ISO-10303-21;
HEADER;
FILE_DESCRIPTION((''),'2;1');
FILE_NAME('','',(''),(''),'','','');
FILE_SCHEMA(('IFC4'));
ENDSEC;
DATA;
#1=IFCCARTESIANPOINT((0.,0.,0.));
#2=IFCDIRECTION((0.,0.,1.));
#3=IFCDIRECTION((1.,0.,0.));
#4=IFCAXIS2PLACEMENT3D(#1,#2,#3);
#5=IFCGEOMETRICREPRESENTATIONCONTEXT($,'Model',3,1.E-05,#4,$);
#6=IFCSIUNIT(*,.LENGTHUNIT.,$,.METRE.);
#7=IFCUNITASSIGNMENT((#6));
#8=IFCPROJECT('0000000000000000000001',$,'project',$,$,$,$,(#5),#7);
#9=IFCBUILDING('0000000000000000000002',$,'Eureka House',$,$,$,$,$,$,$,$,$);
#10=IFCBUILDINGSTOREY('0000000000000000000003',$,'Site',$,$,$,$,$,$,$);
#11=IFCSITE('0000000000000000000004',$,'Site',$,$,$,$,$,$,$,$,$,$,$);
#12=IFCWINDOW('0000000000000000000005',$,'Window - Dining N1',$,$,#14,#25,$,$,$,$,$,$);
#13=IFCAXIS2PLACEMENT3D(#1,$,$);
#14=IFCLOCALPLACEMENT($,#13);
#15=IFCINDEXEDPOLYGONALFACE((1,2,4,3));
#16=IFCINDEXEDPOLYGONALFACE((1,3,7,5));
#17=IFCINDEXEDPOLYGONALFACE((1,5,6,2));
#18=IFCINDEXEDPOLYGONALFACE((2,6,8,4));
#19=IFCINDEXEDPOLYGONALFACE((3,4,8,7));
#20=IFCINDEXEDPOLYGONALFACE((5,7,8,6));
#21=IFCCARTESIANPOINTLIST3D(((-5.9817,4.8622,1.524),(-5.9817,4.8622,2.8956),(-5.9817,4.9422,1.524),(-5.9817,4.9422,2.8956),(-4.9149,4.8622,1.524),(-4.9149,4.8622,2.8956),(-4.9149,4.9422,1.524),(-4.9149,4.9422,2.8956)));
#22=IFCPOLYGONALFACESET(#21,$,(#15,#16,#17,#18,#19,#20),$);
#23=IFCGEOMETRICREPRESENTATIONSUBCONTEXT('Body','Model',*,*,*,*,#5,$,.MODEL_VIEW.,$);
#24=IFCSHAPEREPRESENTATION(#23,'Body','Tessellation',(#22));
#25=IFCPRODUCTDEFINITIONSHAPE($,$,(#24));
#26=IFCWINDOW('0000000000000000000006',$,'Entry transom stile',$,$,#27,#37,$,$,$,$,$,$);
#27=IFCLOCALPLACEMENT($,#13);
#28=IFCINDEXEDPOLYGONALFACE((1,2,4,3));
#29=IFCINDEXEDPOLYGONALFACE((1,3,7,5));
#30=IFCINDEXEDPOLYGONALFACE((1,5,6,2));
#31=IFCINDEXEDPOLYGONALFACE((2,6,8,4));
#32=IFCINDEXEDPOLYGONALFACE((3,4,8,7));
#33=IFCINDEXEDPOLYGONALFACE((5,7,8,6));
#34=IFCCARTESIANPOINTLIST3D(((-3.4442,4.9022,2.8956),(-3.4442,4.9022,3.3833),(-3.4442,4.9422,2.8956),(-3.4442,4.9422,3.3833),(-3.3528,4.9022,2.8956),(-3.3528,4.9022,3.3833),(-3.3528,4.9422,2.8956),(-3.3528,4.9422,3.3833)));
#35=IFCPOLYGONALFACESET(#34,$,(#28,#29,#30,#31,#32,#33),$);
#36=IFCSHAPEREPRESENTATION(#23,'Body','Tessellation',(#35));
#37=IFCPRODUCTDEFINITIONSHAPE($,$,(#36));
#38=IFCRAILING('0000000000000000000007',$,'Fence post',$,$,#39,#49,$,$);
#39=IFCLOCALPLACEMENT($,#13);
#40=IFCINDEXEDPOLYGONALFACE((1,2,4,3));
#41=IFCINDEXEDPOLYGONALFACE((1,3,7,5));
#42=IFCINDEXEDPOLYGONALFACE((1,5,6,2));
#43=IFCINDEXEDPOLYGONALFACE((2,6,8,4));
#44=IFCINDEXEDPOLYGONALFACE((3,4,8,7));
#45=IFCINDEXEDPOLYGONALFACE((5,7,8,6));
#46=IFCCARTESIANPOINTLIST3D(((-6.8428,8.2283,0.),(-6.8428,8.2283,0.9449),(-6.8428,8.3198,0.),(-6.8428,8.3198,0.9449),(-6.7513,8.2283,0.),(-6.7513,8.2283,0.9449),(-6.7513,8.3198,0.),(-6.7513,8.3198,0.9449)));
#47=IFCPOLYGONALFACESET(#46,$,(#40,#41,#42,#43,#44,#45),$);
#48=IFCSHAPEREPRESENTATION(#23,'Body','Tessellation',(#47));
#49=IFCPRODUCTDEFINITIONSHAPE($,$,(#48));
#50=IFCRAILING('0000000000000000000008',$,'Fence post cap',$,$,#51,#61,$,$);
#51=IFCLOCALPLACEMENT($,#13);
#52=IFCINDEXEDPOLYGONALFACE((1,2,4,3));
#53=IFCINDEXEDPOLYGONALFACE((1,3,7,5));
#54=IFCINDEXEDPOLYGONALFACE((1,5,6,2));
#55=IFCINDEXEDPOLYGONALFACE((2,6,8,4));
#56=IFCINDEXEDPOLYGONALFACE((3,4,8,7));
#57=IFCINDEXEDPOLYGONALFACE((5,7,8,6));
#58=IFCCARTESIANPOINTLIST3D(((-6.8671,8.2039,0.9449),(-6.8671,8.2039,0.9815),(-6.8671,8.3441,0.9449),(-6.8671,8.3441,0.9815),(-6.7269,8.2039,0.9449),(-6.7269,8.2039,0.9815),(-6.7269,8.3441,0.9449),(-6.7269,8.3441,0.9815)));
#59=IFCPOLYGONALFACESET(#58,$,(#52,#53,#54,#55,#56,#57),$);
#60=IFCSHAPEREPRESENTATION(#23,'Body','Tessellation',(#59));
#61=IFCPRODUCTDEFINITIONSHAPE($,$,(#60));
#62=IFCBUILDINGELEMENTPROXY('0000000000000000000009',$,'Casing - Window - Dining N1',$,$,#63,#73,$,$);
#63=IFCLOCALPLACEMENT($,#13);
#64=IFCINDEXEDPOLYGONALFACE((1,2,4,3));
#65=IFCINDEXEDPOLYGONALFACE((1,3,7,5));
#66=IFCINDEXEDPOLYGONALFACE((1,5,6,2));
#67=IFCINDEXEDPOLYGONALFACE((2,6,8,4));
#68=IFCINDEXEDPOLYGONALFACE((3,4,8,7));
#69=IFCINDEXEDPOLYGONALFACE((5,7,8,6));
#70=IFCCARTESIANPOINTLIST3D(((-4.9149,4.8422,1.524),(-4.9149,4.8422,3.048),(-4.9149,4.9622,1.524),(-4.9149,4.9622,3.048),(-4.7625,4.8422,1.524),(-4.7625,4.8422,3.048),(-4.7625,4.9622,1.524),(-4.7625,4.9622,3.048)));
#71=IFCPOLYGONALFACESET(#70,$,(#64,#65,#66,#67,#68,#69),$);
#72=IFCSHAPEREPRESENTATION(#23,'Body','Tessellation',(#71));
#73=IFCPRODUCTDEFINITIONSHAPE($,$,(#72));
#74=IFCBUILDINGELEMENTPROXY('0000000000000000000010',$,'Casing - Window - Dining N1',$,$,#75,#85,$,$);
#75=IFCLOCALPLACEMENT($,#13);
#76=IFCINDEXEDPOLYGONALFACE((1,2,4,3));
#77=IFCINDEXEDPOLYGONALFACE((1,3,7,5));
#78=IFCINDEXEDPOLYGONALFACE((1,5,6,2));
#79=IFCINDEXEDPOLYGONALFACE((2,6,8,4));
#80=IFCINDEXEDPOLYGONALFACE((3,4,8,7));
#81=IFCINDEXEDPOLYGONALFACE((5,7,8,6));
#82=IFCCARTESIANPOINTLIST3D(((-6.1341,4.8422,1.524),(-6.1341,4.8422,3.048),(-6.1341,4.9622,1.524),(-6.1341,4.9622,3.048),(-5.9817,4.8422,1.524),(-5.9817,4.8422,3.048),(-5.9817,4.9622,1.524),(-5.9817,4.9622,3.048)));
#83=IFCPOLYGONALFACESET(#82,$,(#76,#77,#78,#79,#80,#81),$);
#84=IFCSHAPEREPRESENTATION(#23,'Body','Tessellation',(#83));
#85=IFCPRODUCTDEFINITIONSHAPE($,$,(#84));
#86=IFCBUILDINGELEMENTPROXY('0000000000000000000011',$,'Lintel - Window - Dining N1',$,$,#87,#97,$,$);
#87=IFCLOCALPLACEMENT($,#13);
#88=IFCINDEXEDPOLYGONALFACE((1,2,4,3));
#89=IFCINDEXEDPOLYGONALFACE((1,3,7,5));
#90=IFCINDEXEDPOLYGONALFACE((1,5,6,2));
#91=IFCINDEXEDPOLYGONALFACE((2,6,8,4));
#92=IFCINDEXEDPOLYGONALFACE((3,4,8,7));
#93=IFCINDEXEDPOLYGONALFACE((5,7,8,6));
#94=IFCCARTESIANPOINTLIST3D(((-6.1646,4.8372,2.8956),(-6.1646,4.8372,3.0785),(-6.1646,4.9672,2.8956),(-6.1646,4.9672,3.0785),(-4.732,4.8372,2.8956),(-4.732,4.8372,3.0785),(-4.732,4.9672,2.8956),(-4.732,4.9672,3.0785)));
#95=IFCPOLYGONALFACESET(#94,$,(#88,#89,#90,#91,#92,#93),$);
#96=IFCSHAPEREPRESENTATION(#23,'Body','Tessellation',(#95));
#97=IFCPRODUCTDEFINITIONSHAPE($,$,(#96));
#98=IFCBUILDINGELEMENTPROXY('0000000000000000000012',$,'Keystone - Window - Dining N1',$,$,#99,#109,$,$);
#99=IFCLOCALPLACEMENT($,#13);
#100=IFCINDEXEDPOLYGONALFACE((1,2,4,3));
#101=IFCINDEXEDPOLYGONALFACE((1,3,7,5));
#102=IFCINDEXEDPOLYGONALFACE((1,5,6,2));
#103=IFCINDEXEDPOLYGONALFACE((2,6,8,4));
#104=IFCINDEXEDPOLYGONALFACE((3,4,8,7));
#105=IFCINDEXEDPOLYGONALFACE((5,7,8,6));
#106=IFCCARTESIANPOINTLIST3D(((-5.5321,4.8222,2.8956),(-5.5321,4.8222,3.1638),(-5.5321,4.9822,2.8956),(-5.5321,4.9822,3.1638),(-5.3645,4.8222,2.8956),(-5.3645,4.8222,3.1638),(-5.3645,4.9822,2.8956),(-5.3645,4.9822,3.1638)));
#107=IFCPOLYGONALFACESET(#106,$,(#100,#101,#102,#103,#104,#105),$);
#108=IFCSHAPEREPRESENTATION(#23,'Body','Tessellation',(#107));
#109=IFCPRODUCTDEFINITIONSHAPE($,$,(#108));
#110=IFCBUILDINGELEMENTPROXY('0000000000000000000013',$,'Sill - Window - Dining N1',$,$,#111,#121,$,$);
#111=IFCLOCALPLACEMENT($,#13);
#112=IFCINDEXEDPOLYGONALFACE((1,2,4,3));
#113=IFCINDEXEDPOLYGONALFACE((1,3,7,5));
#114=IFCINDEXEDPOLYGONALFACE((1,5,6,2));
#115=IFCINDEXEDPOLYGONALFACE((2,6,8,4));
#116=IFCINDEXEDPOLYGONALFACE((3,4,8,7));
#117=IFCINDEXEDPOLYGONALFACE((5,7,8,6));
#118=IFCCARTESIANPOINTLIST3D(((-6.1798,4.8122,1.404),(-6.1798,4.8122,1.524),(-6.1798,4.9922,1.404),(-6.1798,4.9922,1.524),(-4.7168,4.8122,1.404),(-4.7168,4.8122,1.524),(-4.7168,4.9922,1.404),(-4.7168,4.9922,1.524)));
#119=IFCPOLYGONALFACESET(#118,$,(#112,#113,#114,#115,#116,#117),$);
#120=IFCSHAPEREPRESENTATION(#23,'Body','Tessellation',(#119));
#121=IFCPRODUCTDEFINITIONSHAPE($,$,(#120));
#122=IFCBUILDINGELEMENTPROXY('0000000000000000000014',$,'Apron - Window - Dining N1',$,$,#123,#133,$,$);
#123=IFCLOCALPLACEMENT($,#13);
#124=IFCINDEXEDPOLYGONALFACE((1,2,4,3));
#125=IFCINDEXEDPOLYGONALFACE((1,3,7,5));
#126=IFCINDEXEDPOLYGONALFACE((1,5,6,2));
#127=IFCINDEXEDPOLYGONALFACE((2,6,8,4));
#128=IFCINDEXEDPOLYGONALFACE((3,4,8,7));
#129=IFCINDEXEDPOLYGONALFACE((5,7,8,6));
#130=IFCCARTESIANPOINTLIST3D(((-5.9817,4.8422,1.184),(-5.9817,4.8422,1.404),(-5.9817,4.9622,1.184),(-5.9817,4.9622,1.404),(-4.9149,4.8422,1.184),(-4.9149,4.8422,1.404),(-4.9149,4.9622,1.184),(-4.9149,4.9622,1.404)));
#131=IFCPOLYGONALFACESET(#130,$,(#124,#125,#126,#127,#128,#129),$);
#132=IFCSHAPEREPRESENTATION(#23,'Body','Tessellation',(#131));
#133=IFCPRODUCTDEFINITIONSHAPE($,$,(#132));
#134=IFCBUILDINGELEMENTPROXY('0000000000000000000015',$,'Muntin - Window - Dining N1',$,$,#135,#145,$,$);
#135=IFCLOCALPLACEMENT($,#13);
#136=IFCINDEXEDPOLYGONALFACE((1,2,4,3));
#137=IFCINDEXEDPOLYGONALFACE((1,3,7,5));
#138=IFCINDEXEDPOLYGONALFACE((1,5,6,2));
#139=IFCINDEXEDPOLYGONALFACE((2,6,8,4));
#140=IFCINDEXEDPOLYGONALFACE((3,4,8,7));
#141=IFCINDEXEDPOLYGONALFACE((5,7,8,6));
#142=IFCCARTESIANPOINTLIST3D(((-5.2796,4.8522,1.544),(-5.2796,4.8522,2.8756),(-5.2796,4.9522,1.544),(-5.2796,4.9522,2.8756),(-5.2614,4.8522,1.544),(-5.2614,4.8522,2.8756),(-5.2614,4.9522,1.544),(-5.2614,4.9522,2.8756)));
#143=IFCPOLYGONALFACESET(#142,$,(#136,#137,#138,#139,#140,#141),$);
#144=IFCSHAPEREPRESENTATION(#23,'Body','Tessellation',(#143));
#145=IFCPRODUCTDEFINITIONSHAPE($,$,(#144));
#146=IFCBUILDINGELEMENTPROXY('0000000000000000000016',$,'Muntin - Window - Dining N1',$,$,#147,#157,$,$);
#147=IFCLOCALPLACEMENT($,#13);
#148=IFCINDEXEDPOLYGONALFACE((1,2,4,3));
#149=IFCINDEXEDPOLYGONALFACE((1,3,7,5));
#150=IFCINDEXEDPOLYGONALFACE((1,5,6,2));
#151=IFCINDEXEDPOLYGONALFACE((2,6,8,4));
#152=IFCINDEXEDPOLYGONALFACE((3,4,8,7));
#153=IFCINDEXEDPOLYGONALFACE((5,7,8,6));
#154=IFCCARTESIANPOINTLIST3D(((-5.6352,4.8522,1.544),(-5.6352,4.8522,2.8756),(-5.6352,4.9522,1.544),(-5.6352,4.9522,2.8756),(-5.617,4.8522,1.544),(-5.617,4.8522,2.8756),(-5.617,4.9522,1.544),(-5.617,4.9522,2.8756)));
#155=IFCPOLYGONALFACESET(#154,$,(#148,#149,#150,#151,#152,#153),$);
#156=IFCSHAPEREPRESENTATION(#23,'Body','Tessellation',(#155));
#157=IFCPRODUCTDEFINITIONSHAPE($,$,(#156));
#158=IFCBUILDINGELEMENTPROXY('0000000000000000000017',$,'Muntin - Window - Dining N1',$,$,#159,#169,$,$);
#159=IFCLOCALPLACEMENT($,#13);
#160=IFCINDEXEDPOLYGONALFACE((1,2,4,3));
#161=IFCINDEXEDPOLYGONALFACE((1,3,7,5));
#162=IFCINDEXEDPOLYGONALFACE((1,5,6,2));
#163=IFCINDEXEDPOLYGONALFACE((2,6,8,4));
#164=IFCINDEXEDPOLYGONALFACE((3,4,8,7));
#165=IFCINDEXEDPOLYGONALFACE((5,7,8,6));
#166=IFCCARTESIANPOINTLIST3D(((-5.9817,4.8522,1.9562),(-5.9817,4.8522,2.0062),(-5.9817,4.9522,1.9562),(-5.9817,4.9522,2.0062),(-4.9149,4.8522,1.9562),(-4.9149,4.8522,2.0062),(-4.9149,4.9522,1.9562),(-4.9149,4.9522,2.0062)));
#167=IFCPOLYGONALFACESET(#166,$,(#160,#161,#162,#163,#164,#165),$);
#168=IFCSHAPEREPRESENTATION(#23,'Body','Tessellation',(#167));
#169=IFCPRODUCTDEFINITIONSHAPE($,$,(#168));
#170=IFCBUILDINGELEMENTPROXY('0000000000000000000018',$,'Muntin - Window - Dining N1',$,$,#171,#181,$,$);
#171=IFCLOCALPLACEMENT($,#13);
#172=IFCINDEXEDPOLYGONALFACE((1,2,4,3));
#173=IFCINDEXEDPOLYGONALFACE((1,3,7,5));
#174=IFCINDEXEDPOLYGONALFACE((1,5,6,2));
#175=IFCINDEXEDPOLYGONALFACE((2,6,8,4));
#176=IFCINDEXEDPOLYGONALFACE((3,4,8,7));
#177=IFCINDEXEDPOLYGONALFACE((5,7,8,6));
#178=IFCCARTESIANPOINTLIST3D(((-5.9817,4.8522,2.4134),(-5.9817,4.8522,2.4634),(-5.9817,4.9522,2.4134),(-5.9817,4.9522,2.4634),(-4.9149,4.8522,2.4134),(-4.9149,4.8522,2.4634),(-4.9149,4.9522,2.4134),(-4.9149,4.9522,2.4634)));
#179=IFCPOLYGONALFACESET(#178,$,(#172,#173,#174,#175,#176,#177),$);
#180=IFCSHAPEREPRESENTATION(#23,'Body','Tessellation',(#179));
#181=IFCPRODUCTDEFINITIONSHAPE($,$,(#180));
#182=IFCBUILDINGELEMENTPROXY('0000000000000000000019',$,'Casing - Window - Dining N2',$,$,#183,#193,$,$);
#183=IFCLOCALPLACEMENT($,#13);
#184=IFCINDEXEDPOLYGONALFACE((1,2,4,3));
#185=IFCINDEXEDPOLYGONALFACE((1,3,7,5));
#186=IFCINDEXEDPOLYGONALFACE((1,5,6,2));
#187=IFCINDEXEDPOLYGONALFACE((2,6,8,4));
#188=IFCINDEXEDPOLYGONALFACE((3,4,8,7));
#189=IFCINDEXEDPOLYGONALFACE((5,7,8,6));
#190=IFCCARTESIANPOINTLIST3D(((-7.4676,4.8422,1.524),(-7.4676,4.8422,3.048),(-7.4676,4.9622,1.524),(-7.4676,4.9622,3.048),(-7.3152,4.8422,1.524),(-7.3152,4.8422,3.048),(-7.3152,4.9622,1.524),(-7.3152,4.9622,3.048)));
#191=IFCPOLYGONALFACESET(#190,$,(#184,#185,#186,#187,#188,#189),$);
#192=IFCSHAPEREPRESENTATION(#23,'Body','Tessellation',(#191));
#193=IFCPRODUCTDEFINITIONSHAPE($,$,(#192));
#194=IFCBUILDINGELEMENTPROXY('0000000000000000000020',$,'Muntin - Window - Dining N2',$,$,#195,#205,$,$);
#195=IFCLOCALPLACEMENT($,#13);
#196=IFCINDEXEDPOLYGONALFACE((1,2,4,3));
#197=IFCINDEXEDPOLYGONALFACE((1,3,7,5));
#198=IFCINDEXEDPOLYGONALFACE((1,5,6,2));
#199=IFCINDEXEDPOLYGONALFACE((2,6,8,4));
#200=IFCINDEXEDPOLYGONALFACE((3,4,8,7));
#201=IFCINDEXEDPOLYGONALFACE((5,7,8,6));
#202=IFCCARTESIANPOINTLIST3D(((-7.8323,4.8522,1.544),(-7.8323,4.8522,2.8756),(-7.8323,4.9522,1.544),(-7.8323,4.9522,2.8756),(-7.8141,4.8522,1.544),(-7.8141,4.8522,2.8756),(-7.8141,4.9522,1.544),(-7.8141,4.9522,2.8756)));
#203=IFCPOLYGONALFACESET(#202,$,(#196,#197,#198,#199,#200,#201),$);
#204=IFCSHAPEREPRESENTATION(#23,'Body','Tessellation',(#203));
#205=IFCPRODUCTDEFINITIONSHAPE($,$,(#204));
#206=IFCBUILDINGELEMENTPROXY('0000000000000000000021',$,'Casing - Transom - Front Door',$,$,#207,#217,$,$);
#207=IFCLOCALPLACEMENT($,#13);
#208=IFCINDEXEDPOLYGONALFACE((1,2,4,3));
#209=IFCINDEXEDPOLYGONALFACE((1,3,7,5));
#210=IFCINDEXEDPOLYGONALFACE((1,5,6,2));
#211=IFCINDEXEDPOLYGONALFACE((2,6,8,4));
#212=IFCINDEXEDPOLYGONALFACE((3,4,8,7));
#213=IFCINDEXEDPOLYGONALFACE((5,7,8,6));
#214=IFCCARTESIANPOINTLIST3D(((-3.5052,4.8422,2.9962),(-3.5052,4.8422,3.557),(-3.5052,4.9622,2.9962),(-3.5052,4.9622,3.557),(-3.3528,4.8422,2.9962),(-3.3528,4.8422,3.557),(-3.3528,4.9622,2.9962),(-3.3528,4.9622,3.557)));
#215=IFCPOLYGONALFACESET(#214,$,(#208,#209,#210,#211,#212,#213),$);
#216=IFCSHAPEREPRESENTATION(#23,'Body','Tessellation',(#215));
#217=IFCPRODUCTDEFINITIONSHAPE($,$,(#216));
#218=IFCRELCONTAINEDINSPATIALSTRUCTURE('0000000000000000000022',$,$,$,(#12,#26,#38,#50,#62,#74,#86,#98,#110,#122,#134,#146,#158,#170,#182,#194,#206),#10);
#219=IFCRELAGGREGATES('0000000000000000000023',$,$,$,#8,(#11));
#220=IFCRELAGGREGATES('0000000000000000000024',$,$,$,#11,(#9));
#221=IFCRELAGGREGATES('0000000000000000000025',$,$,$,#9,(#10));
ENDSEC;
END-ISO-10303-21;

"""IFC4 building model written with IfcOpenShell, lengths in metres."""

from ifc_helpers import new_model, si_unit, frame, origin, origin_with_axes, origin_2d, place, context, subcontext, project, spatial, rectangle, extrude, element, save


model = new_model("IFC4")

# Units and contexts
model_context = context("Model", 3, precision=1e-05, world=origin_with_axes())
body_context = subcontext(model_context, "Body", "Model", "MODEL_VIEW")
ifc_project = project(units=[si_unit("LENGTHUNIT", "METRE")], contexts=[model_context])

# Site, building, storey
site = spatial("IfcSite", under=ifc_project, Name="Site")
building = spatial("IfcBuilding", under=site, Name="Eureka House")
storey = spatial("IfcBuildingStorey", under=building, Name="Site")

# Windows
window_1_placement = place(None, frame((-5.4483, 4.9022, 1.524), z_axis=(0.0, 0.0, 1.0), x_axis=(1.0, 0.0, 0.0)))
element("IfcWindow", 1, at=window_1_placement, inside=storey, Name="Window - Dining N1", context=body_context, shape_type="SweptSolid", body=[
    extrude(rectangle(XDim=1.0668, YDim=0.08, at=origin_2d()), origin(), (0.0, 0.0, 1.0), 1.3716),
])
window_2_placement = place(None, frame((-3.3985, 4.9222, 2.8956), z_axis=(0.0, 0.0, 1.0), x_axis=(1.0, 0.0, 0.0)))
element("IfcWindow", 2, at=window_2_placement, inside=storey, Name="Entry transom stile", context=body_context, shape_type="SweptSolid", body=[
    extrude(rectangle(XDim=0.0914, YDim=0.04, at=origin_2d()), origin(), (0.0, 0.0, 1.0), 0.4877),
])

# Railings
railing_1_placement = place(None, frame((-6.797, 8.274, 0.0), z_axis=(0.0, 0.0, 1.0), x_axis=(1.0, 0.0, 0.0)))
element("IfcRailing", 3, at=railing_1_placement, inside=storey, Name="Fence post", context=body_context, shape_type="SweptSolid", body=[
    extrude(rectangle(XDim=0.0914, YDim=0.0914, at=origin_2d()), origin(), (0.0, 0.0, 1.0), 0.9449),
])
railing_2_placement = place(None, frame((-6.797, 8.274, 0.9449), z_axis=(0.0, 0.0, 1.0), x_axis=(1.0, 0.0, 0.0)))
element("IfcRailing", 4, at=railing_2_placement, inside=storey, Name="Fence post cap", context=body_context, shape_type="SweptSolid", body=[
    extrude(rectangle(XDim=0.1402, YDim=0.1402, at=origin_2d()), origin(), (0.0, 0.0, 1.0), 0.0366),
])

# Building element proxies
for number, where, z_axis, x_axis, name in (
    (5, (-4.8387, 4.9022, 1.524), (0.0, 0.0, 1.0), (1.0, 0.0, 0.0), "Casing - Window - Dining N1"),
    (6, (-6.0579, 4.9022, 1.524), (0.0, 0.0, 1.0), (1.0, 0.0, 0.0), "Casing - Window - Dining N1"),
):
    element("IfcBuildingElementProxy", number, at=place(None, frame(where, z_axis=z_axis, x_axis=x_axis)), inside=storey, Name=name, context=body_context, shape_type="SweptSolid", body=[
        extrude(rectangle(XDim=0.1524, YDim=0.12, at=origin_2d()), origin(), (0.0, 0.0, 1.0), 1.524),
    ])
proxy_1_placement = place(None, frame((-5.4483, 4.9022, 2.8956), z_axis=(0.0, 0.0, 1.0), x_axis=(1.0, 0.0, 0.0)))
element("IfcBuildingElementProxy", 7, at=proxy_1_placement, inside=storey, Name="Lintel - Window - Dining N1", context=body_context, shape_type="SweptSolid", body=[
    extrude(rectangle(XDim=1.4326, YDim=0.13, at=origin_2d()), origin(), (0.0, 0.0, 1.0), 0.1829),
])
proxy_2_placement = place(None, frame((-5.4483, 4.9022, 2.8956), z_axis=(0.0, 0.0, 1.0), x_axis=(1.0, 0.0, 0.0)))
element("IfcBuildingElementProxy", 8, at=proxy_2_placement, inside=storey, Name="Keystone - Window - Dining N1", context=body_context, shape_type="SweptSolid", body=[
    extrude(rectangle(XDim=0.1676, YDim=0.16, at=origin_2d()), origin(), (0.0, 0.0, 1.0), 0.2682),
])
proxy_3_placement = place(None, frame((-5.4483, 4.9022, 1.404), z_axis=(0.0, 0.0, 1.0), x_axis=(1.0, 0.0, 0.0)))
element("IfcBuildingElementProxy", 9, at=proxy_3_placement, inside=storey, Name="Sill - Window - Dining N1", context=body_context, shape_type="SweptSolid", body=[
    extrude(rectangle(XDim=1.463, YDim=0.18, at=origin_2d()), origin(), (0.0, 0.0, 1.0), 0.12),
])
proxy_4_placement = place(None, frame((-5.4483, 4.9022, 1.184), z_axis=(0.0, 0.0, 1.0), x_axis=(1.0, 0.0, 0.0)))
element("IfcBuildingElementProxy", 10, at=proxy_4_placement, inside=storey, Name="Apron - Window - Dining N1", context=body_context, shape_type="SweptSolid", body=[
    extrude(rectangle(XDim=1.0668, YDim=0.12, at=origin_2d()), origin(), (0.0, 0.0, 1.0), 0.22),
])
for number, where, z_axis, x_axis, name in (
    (11, (-5.2705, 4.9022, 1.544), (0.0, 0.0, 1.0), (1.0, 0.0, 0.0), "Muntin - Window - Dining N1"),
    (12, (-5.6261, 4.9022, 1.544), (0.0, 0.0, 1.0), (1.0, 0.0, 0.0), "Muntin - Window - Dining N1"),
):
    element("IfcBuildingElementProxy", number, at=place(None, frame(where, z_axis=z_axis, x_axis=x_axis)), inside=storey, Name=name, context=body_context, shape_type="SweptSolid", body=[
        extrude(rectangle(XDim=0.0183, YDim=0.1, at=origin_2d()), origin(), (0.0, 0.0, 1.0), 1.3316),
    ])
proxy_5_placement = place(None, frame((-5.4483, 4.9022, 1.9562), z_axis=(0.0, 0.0, 1.0), x_axis=(1.0, 0.0, 0.0)))
element("IfcBuildingElementProxy", 13, at=proxy_5_placement, inside=storey, Name="Muntin - Window - Dining N1", context=body_context, shape_type="SweptSolid", body=[
    extrude(rectangle(XDim=1.0668, YDim=0.1, at=origin_2d()), origin(), (0.0, 0.0, 1.0), 0.05),
])
proxy_6_placement = place(None, frame((-5.4483, 4.9022, 2.4134), z_axis=(0.0, 0.0, 1.0), x_axis=(1.0, 0.0, 0.0)))
element("IfcBuildingElementProxy", 14, at=proxy_6_placement, inside=storey, Name="Muntin - Window - Dining N1", context=body_context, shape_type="SweptSolid", body=[
    extrude(rectangle(XDim=1.0668, YDim=0.1, at=origin_2d()), origin(), (0.0, 0.0, 1.0), 0.05),
])
proxy_7_placement = place(None, frame((-7.3914, 4.9022, 1.524), z_axis=(0.0, 0.0, 1.0), x_axis=(1.0, 0.0, 0.0)))
element("IfcBuildingElementProxy", 15, at=proxy_7_placement, inside=storey, Name="Casing - Window - Dining N2", context=body_context, shape_type="SweptSolid", body=[
    extrude(rectangle(XDim=0.1524, YDim=0.12, at=origin_2d()), origin(), (0.0, 0.0, 1.0), 1.524),
])
proxy_8_placement = place(None, frame((-7.8232, 4.9022, 1.544), z_axis=(0.0, 0.0, 1.0), x_axis=(1.0, 0.0, 0.0)))
element("IfcBuildingElementProxy", 16, at=proxy_8_placement, inside=storey, Name="Muntin - Window - Dining N2", context=body_context, shape_type="SweptSolid", body=[
    extrude(rectangle(XDim=0.0183, YDim=0.1, at=origin_2d()), origin(), (0.0, 0.0, 1.0), 1.3316),
])
proxy_9_placement = place(None, frame((-3.429, 4.9022, 2.9962), z_axis=(0.0, 0.0, 1.0), x_axis=(1.0, 0.0, 0.0)))
element("IfcBuildingElementProxy", 17, at=proxy_9_placement, inside=storey, Name="Casing - Transom - Front Door", context=body_context, shape_type="SweptSolid", body=[
    extrude(rectangle(XDim=0.1524, YDim=0.12, at=origin_2d()), origin(), (0.0, 0.0, 1.0), 0.5608),
])

save(model, "model.ifc")
